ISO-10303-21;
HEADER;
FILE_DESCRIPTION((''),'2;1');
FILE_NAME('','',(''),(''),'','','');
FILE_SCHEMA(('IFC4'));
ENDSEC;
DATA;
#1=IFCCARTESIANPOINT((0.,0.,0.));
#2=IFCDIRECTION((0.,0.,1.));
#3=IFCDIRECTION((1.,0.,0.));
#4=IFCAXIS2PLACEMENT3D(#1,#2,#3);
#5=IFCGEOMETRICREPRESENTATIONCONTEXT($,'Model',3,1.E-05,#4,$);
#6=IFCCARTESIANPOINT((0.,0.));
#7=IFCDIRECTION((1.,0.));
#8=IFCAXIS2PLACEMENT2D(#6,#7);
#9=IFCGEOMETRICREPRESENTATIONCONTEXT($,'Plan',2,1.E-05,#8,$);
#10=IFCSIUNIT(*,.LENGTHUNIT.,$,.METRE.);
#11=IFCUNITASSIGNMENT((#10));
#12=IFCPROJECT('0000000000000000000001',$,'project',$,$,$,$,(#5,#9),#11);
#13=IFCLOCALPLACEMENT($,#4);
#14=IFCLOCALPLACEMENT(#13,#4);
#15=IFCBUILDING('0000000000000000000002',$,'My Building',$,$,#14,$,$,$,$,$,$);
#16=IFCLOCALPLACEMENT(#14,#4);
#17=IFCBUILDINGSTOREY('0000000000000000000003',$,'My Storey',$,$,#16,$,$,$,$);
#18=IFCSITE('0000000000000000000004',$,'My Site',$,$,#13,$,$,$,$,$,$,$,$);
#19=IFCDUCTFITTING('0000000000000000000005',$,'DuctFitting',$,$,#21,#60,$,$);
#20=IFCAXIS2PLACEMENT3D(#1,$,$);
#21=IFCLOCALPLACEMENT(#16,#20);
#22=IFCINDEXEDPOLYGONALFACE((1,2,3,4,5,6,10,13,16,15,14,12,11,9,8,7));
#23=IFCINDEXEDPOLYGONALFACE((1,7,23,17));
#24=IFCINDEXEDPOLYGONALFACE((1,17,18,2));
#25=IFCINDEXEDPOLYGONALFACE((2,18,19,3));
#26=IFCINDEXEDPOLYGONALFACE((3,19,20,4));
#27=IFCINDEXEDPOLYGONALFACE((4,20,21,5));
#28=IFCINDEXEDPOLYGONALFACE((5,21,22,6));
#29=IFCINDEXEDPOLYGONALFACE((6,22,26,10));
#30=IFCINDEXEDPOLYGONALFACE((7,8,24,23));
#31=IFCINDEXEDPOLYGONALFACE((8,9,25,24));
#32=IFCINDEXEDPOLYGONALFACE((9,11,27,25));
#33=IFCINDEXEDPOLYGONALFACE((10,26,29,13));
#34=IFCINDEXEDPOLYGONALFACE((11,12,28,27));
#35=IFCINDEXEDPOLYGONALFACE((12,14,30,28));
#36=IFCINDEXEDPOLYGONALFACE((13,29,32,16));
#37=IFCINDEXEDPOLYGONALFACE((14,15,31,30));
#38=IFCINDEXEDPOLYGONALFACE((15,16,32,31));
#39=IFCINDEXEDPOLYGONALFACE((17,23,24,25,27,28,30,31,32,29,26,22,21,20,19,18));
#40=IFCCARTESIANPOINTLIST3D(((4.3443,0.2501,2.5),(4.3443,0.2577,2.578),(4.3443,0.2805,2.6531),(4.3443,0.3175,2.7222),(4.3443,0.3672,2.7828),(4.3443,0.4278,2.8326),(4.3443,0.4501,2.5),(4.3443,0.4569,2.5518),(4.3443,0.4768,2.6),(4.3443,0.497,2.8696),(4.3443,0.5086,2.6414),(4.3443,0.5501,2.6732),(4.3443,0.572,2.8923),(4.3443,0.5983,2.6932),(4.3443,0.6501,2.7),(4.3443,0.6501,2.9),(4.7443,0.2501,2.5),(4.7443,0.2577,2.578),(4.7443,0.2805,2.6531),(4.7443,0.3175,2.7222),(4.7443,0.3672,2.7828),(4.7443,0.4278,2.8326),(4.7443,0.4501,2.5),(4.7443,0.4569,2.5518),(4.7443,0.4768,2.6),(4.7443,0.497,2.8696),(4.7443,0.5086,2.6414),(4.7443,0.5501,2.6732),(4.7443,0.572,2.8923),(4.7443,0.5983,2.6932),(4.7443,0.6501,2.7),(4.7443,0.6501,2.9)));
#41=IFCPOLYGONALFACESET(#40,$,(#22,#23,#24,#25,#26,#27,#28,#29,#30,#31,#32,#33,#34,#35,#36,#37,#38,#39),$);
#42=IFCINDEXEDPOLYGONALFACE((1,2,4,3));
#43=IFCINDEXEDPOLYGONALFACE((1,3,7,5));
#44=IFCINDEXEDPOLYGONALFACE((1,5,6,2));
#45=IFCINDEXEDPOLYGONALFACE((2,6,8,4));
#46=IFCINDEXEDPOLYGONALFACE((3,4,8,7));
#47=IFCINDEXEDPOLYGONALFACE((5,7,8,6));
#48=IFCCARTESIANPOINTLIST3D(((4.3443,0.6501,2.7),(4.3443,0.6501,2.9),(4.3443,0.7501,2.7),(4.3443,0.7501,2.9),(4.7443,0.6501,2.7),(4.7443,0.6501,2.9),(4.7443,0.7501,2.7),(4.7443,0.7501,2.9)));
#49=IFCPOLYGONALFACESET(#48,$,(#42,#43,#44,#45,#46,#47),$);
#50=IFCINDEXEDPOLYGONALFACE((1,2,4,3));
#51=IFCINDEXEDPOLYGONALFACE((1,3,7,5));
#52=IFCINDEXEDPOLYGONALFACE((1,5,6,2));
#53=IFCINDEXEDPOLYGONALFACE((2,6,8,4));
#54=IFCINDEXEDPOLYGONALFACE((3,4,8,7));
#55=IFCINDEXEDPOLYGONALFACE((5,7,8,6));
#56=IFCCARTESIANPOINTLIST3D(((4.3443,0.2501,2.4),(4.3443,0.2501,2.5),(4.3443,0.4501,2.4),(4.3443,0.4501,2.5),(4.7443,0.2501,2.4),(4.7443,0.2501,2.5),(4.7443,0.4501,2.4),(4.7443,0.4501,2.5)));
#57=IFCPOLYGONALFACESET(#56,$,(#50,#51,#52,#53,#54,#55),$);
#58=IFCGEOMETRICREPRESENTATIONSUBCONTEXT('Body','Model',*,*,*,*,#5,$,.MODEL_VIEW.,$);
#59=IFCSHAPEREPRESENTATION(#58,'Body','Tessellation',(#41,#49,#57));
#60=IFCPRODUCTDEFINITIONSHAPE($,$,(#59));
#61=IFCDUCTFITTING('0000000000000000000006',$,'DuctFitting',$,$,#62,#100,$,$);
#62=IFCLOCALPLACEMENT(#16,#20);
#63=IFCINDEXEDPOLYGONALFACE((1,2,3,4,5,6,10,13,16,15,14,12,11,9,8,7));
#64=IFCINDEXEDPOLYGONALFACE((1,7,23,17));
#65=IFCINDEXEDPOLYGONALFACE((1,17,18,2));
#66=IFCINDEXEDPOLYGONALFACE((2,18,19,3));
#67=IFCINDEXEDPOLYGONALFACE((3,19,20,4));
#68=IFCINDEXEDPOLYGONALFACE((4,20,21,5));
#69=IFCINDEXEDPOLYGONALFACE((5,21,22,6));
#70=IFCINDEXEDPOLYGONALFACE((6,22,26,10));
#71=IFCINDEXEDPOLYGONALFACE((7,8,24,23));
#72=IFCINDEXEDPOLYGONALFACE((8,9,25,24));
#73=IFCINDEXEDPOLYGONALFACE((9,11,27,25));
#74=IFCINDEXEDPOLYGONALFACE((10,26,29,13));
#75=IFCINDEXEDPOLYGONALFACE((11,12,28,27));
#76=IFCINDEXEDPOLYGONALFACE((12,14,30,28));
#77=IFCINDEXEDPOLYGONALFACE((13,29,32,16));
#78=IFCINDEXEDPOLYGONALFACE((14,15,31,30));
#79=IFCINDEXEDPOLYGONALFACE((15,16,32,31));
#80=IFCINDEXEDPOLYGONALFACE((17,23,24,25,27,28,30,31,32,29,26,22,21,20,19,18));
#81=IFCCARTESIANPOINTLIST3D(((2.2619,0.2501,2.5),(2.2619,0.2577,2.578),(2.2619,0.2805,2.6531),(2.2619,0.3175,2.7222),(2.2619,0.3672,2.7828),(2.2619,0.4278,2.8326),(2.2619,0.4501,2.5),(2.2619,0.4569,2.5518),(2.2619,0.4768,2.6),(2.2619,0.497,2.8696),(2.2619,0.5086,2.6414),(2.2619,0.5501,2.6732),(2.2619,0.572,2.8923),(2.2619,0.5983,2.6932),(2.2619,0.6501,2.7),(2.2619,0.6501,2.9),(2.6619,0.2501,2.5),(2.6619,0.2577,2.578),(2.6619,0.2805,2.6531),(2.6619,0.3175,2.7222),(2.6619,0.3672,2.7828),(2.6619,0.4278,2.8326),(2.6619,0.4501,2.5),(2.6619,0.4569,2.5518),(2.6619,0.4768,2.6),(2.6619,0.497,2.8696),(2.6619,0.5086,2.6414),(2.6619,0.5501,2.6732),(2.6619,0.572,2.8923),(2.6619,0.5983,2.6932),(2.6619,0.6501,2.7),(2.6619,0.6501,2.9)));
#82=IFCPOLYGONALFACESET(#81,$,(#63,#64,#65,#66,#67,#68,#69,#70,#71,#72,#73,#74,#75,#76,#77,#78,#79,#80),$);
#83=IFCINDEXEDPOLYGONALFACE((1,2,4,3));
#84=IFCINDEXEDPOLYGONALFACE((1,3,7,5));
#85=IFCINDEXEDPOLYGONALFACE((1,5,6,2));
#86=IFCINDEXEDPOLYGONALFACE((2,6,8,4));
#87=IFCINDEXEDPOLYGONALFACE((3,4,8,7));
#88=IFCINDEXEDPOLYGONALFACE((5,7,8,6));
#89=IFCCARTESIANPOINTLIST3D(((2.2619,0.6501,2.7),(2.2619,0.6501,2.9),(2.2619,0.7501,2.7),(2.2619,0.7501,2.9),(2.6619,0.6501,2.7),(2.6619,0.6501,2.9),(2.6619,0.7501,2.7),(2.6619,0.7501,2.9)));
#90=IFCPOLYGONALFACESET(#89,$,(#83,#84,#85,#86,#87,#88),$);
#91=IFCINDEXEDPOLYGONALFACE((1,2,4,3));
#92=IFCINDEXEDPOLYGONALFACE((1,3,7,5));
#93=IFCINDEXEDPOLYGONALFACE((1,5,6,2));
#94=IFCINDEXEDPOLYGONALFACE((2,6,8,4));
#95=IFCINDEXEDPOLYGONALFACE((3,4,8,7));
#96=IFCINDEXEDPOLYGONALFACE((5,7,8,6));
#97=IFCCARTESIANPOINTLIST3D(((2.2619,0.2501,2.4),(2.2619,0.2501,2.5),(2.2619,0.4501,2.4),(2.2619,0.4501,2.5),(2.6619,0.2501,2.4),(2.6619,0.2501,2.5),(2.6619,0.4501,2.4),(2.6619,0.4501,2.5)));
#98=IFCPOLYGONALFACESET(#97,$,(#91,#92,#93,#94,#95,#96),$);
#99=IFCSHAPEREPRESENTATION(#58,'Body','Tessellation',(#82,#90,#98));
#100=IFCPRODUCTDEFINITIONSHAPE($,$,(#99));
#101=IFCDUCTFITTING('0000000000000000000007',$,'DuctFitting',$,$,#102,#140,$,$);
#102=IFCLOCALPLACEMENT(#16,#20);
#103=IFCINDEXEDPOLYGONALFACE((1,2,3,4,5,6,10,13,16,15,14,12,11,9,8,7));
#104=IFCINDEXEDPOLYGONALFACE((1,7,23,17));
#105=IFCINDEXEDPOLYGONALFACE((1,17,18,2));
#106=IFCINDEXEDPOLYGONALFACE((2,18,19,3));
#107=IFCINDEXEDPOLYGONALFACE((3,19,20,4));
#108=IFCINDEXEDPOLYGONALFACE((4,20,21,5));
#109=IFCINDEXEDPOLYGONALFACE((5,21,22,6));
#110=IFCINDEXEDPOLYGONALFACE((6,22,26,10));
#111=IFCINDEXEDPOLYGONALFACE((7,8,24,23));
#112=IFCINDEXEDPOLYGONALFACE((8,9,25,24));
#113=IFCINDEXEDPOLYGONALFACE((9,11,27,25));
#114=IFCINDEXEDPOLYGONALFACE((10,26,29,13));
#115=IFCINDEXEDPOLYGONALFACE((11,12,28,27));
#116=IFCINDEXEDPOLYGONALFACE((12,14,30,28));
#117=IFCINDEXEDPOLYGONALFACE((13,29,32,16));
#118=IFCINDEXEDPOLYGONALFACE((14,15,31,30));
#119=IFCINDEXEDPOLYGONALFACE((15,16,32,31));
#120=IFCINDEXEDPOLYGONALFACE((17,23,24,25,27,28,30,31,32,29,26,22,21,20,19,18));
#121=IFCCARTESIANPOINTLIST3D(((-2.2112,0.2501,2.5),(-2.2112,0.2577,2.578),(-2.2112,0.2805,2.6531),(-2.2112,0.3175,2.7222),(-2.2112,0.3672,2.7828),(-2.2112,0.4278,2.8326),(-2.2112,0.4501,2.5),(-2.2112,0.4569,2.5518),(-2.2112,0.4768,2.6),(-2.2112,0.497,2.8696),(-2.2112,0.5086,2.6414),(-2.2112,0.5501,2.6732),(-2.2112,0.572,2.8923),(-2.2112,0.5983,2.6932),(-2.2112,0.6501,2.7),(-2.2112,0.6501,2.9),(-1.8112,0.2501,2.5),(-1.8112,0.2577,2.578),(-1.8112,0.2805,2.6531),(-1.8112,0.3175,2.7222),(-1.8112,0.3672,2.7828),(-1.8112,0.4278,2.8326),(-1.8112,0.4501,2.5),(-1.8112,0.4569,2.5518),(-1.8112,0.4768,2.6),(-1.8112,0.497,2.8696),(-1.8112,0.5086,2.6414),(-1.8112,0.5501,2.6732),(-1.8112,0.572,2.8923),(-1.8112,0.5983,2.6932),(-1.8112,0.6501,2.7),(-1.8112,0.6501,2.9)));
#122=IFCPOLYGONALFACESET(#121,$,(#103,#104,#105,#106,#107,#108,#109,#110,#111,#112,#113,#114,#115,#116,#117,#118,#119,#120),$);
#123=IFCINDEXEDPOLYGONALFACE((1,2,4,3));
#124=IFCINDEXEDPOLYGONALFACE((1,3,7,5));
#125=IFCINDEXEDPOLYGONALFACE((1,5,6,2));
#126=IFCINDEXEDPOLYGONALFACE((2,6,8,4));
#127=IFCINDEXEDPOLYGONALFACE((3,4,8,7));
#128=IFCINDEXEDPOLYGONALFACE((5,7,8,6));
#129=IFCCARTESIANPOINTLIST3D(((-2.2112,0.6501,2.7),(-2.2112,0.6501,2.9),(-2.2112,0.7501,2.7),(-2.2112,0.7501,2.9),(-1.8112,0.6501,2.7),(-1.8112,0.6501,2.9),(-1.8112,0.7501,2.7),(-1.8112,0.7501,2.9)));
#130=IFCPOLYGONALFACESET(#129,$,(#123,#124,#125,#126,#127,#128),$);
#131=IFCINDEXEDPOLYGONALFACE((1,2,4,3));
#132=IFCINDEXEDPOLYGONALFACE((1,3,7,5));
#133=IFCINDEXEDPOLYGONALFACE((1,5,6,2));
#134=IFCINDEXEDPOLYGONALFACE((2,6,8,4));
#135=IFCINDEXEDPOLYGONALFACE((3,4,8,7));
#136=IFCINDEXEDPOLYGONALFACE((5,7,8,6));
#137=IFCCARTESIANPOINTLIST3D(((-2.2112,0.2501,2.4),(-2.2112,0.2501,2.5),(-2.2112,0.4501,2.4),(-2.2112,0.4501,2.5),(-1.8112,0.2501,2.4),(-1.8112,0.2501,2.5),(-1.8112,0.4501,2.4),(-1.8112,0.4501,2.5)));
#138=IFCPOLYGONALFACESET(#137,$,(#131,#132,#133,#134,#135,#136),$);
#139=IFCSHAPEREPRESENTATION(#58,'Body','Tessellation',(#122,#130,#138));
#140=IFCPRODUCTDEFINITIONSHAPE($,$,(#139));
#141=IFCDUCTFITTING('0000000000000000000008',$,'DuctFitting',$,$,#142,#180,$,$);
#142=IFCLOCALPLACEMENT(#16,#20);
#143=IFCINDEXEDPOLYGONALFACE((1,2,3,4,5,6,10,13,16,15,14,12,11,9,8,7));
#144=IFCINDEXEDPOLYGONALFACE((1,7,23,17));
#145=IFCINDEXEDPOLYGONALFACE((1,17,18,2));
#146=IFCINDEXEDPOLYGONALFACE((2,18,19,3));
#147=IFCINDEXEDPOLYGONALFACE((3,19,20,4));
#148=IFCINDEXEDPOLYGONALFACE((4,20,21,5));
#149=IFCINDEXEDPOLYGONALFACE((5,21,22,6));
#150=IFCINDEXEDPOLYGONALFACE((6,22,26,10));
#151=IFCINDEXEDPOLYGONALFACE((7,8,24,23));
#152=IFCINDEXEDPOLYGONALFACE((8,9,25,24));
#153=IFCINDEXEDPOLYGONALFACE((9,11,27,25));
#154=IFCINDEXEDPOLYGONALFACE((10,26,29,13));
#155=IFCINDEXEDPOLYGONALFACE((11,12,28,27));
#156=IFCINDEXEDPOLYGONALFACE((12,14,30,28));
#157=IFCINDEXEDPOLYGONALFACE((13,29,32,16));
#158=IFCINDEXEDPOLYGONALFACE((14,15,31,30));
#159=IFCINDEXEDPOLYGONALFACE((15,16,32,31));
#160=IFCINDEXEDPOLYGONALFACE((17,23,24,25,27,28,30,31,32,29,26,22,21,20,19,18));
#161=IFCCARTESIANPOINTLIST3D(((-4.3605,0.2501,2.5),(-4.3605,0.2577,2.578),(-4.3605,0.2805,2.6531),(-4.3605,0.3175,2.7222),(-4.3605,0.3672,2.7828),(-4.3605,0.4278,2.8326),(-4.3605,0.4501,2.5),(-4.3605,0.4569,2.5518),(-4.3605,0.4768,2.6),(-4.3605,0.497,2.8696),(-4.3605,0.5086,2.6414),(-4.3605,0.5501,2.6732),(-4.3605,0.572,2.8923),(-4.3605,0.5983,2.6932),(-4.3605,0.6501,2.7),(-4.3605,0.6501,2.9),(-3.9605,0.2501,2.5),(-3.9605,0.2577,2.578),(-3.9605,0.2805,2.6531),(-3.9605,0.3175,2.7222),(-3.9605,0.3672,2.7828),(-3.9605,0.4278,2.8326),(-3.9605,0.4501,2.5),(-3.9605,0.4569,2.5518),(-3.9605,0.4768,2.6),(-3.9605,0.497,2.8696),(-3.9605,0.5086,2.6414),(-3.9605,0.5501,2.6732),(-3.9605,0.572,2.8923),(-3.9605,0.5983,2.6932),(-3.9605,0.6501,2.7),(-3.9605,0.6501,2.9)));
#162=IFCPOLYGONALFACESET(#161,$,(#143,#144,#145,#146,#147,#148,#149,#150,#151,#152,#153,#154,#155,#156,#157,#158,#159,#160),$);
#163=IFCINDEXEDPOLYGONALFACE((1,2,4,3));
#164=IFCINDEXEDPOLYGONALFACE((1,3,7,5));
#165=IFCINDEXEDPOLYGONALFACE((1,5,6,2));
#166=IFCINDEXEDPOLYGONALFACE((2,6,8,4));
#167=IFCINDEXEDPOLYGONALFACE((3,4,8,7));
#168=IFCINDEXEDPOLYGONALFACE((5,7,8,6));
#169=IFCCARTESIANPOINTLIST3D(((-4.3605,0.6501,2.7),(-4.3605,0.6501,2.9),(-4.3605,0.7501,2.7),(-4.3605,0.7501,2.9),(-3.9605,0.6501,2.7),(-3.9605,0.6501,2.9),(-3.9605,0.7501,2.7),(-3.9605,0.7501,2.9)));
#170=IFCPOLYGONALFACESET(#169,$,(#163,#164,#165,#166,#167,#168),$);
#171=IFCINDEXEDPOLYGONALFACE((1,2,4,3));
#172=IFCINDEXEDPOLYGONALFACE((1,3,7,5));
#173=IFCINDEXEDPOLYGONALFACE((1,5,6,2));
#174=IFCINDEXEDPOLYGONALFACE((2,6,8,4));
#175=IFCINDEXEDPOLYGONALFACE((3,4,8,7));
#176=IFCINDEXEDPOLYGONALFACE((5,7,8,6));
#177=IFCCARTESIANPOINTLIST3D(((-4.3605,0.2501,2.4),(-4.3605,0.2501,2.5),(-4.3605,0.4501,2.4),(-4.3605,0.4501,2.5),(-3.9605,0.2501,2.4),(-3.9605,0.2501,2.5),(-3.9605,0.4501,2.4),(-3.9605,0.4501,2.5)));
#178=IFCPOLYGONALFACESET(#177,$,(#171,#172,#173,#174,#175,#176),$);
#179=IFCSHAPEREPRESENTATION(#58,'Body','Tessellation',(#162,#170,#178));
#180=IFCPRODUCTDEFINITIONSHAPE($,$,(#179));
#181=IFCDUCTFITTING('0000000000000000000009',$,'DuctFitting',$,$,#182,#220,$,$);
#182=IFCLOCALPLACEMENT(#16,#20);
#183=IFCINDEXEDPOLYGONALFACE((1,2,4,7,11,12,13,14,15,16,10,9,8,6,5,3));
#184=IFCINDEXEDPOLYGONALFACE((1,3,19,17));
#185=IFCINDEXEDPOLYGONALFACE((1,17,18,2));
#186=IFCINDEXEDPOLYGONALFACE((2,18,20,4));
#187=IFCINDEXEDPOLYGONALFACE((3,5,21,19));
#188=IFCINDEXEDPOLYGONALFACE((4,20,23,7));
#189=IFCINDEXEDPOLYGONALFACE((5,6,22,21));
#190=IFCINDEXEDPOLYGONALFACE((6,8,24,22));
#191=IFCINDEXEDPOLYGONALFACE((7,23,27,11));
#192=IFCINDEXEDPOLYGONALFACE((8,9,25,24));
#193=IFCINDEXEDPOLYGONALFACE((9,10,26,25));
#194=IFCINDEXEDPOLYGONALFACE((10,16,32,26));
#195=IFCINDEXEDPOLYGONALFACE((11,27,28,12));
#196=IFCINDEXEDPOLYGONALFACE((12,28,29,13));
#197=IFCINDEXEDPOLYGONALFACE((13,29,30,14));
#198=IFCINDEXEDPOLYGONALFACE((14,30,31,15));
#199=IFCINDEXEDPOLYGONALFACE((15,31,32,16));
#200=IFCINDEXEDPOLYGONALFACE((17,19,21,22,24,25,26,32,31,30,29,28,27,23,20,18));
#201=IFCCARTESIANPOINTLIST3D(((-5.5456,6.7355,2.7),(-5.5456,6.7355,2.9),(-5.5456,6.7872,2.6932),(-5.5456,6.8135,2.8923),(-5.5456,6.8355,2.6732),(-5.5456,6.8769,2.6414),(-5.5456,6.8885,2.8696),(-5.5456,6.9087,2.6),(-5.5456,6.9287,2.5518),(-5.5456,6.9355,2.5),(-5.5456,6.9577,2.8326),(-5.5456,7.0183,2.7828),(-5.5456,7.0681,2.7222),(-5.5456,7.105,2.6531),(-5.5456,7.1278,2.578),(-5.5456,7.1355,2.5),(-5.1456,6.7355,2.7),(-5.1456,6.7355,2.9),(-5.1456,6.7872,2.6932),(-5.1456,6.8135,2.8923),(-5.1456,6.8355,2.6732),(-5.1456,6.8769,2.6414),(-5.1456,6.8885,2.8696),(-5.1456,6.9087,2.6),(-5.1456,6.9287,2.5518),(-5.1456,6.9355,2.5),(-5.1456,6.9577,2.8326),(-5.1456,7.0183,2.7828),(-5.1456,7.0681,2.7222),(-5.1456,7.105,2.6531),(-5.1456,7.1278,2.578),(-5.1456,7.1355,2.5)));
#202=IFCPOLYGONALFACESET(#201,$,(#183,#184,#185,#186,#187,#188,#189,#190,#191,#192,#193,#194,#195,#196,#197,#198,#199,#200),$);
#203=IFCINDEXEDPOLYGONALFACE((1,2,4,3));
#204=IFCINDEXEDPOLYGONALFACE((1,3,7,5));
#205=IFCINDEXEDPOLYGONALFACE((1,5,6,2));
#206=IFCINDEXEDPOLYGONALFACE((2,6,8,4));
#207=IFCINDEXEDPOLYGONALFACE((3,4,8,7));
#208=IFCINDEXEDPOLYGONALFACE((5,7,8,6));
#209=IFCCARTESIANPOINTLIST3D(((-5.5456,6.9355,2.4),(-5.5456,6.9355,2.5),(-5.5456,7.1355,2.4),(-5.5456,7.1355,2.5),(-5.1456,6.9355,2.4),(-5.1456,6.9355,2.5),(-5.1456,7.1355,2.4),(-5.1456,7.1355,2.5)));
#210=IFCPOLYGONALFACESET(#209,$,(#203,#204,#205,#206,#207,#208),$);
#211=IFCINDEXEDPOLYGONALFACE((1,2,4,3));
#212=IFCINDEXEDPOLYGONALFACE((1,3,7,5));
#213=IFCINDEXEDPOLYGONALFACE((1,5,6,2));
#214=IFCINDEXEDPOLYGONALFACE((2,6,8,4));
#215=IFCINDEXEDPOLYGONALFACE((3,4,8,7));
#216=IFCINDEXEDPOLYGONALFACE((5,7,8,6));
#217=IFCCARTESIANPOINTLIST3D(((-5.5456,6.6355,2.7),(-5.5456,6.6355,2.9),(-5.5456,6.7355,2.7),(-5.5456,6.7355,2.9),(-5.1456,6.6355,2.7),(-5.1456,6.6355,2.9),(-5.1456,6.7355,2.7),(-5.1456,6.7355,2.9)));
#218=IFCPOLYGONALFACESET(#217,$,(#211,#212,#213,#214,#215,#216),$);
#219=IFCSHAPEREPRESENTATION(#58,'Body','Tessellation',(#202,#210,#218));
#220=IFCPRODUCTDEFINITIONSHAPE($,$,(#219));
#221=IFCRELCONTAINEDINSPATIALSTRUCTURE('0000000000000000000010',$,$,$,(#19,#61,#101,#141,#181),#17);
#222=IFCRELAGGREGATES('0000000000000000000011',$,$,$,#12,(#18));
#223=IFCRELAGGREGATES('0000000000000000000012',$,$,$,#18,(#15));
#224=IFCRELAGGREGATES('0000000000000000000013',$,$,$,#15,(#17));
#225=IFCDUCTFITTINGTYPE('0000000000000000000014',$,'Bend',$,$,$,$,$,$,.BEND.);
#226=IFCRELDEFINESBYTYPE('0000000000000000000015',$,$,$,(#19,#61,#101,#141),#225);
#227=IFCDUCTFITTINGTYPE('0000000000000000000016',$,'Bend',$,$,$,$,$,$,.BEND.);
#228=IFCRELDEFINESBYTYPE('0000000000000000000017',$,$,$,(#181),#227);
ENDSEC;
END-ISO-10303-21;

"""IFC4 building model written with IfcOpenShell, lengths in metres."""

from ifc_helpers import new_model, si_unit, frame, origin_with_axes, origin_2d_with_axis, place, context, subcontext, project, spatial, line, arc, indexed_curve, rectangle, outline, extrude, source, transform, mapped, type_object, type_shapes, element, save


model = new_model("IFC4")

# Units and contexts
model_context = context("Model", 3, precision=1e-05, world=origin_with_axes())
plan_context = context("Plan", 2, precision=1e-05, world=origin_2d_with_axis())
body_context = subcontext(model_context, "Body", "Model", "MODEL_VIEW")
ifc_project = project(units=[si_unit("LENGTHUNIT", "METRE")], contexts=[model_context, plan_context])

# Site, building, storey
site_placement = place(None, origin_with_axes())
site = spatial("IfcSite", under=ifc_project, at=site_placement, Name="My Site")
building_placement = place(site_placement, origin_with_axes())
building = spatial("IfcBuilding", under=site, at=building_placement, Name="My Building")
storey_placement = place(building_placement, origin_with_axes())
storey = spatial("IfcBuildingStorey", under=building, at=storey_placement, Name="My Storey")

# Duct fittings
duct_fitting_type_1 = type_object("IfcDuctFittingType", Name="Bend", PredefinedType="BEND")
shared_shape_1 = source(origin_with_axes(), body_context, "Body", "SweptSolid", [
    extrude(outline(indexed_curve([(-0.1, 0.0), (-0.1586, -0.1414), (-0.3, -0.2), (-0.3, -0.4), (-0.0172, -0.2828), (0.1, 0.0)], segments=[arc(1, 2, 3), line(3, 4), arc(4, 5, 6), line(6, 1)])), frame((-0.2, 0.0, -0.1), z_axis=(1.0, 0.0, 0.0), x_axis=(0.0, 1.0, 0.0)), (0.0, 0.0, 1.0), 0.4),
    extrude(rectangle(XDim=0.4, YDim=0.2), origin_with_axes(), (0.0, 0.0, -1.0), 0.1),
    extrude(rectangle(XDim=0.4, YDim=0.2), frame((0.0, -0.3, -0.4), z_axis=(0.0, -1.0, 0.0), x_axis=(1.0, 0.0, 0.0)), (0.0, 0.0, 1.0), 0.1),
])
type_shapes(duct_fitting_type_1, [shared_shape_1])
for number, where, z_axis, x_axis, name in (
    (1, (4.5443, 0.7501, 2.8), (0.0, 1.0, 0.0), (-1.0, 0.0, 0.0), "DuctFitting"),
    (2, (2.4619, 0.7501, 2.8), (0.0, 1.0, 0.0), (-1.0, 0.0, 0.0), "DuctFitting"),
    (3, (-2.0112, 0.7501, 2.8), (0.0, 1.0, 0.0), (-1.0, 0.0, 0.0), "DuctFitting"),
    (4, (-4.1605, 0.7501, 2.8), (0.0, 1.0, 0.0), (-1.0, 0.0, 0.0), "DuctFitting"),
):
    element("IfcDuctFitting", number, at=place(storey_placement, frame(where, z_axis=z_axis, x_axis=x_axis)), inside=storey, type_object=duct_fitting_type_1, Name=name, context=body_context, shape_type="MappedRepresentation", body=[
        mapped(shared_shape_1, transform((0.0, 0.0, 0.0), x_axis=(1.0, 0.0, 0.0), y_axis=(0.0, 1.0, 0.0), z_axis=(0.0, 0.0, 1.0), scale=1.0)),
    ])
duct_fitting_type_2 = type_object("IfcDuctFittingType", Name="Bend", PredefinedType="BEND")
shared_shape_2 = source(origin_with_axes(), body_context, "Body", "SweptSolid", [
    extrude(outline(indexed_curve([(0.1, 0.0), (0.1586, -0.1414), (0.3, -0.2), (0.3, -0.4), (0.0172, -0.2828), (-0.1, 0.0)], segments=[arc(1, 2, 3), line(3, 4), arc(4, 5, 6), line(6, 1)])), frame((-0.2, 0.0, -0.1), z_axis=(1.0, 0.0, 0.0), x_axis=(0.0, 1.0, 0.0)), (0.0, 0.0, 1.0), 0.4),
    extrude(rectangle(XDim=0.4, YDim=0.2), origin_with_axes(), (0.0, 0.0, -1.0), 0.1),
    extrude(rectangle(XDim=0.4, YDim=0.2), frame((0.0, 0.3, -0.4), z_axis=(0.0, 1.0, 0.0), x_axis=(1.0, 0.0, 0.0)), (0.0, 0.0, 1.0), 0.1),
])
type_shapes(duct_fitting_type_2, [shared_shape_2])
duct_fitting_1_placement = place(storey_placement, frame((-5.3456, 7.0355, 2.4), z_axis=(0.0, 0.0, -1.0), x_axis=(1.0, 0.0, 0.0)))
element("IfcDuctFitting", 5, at=duct_fitting_1_placement, inside=storey, type_object=duct_fitting_type_2, Name="DuctFitting", context=body_context, shape_type="MappedRepresentation", body=[
    mapped(shared_shape_2, transform((0.0, 0.0, 0.0), x_axis=(1.0, 0.0, 0.0), y_axis=(0.0, 1.0, 0.0), z_axis=(0.0, 0.0, 1.0), scale=1.0)),
])

save(model, "model.ifc")
